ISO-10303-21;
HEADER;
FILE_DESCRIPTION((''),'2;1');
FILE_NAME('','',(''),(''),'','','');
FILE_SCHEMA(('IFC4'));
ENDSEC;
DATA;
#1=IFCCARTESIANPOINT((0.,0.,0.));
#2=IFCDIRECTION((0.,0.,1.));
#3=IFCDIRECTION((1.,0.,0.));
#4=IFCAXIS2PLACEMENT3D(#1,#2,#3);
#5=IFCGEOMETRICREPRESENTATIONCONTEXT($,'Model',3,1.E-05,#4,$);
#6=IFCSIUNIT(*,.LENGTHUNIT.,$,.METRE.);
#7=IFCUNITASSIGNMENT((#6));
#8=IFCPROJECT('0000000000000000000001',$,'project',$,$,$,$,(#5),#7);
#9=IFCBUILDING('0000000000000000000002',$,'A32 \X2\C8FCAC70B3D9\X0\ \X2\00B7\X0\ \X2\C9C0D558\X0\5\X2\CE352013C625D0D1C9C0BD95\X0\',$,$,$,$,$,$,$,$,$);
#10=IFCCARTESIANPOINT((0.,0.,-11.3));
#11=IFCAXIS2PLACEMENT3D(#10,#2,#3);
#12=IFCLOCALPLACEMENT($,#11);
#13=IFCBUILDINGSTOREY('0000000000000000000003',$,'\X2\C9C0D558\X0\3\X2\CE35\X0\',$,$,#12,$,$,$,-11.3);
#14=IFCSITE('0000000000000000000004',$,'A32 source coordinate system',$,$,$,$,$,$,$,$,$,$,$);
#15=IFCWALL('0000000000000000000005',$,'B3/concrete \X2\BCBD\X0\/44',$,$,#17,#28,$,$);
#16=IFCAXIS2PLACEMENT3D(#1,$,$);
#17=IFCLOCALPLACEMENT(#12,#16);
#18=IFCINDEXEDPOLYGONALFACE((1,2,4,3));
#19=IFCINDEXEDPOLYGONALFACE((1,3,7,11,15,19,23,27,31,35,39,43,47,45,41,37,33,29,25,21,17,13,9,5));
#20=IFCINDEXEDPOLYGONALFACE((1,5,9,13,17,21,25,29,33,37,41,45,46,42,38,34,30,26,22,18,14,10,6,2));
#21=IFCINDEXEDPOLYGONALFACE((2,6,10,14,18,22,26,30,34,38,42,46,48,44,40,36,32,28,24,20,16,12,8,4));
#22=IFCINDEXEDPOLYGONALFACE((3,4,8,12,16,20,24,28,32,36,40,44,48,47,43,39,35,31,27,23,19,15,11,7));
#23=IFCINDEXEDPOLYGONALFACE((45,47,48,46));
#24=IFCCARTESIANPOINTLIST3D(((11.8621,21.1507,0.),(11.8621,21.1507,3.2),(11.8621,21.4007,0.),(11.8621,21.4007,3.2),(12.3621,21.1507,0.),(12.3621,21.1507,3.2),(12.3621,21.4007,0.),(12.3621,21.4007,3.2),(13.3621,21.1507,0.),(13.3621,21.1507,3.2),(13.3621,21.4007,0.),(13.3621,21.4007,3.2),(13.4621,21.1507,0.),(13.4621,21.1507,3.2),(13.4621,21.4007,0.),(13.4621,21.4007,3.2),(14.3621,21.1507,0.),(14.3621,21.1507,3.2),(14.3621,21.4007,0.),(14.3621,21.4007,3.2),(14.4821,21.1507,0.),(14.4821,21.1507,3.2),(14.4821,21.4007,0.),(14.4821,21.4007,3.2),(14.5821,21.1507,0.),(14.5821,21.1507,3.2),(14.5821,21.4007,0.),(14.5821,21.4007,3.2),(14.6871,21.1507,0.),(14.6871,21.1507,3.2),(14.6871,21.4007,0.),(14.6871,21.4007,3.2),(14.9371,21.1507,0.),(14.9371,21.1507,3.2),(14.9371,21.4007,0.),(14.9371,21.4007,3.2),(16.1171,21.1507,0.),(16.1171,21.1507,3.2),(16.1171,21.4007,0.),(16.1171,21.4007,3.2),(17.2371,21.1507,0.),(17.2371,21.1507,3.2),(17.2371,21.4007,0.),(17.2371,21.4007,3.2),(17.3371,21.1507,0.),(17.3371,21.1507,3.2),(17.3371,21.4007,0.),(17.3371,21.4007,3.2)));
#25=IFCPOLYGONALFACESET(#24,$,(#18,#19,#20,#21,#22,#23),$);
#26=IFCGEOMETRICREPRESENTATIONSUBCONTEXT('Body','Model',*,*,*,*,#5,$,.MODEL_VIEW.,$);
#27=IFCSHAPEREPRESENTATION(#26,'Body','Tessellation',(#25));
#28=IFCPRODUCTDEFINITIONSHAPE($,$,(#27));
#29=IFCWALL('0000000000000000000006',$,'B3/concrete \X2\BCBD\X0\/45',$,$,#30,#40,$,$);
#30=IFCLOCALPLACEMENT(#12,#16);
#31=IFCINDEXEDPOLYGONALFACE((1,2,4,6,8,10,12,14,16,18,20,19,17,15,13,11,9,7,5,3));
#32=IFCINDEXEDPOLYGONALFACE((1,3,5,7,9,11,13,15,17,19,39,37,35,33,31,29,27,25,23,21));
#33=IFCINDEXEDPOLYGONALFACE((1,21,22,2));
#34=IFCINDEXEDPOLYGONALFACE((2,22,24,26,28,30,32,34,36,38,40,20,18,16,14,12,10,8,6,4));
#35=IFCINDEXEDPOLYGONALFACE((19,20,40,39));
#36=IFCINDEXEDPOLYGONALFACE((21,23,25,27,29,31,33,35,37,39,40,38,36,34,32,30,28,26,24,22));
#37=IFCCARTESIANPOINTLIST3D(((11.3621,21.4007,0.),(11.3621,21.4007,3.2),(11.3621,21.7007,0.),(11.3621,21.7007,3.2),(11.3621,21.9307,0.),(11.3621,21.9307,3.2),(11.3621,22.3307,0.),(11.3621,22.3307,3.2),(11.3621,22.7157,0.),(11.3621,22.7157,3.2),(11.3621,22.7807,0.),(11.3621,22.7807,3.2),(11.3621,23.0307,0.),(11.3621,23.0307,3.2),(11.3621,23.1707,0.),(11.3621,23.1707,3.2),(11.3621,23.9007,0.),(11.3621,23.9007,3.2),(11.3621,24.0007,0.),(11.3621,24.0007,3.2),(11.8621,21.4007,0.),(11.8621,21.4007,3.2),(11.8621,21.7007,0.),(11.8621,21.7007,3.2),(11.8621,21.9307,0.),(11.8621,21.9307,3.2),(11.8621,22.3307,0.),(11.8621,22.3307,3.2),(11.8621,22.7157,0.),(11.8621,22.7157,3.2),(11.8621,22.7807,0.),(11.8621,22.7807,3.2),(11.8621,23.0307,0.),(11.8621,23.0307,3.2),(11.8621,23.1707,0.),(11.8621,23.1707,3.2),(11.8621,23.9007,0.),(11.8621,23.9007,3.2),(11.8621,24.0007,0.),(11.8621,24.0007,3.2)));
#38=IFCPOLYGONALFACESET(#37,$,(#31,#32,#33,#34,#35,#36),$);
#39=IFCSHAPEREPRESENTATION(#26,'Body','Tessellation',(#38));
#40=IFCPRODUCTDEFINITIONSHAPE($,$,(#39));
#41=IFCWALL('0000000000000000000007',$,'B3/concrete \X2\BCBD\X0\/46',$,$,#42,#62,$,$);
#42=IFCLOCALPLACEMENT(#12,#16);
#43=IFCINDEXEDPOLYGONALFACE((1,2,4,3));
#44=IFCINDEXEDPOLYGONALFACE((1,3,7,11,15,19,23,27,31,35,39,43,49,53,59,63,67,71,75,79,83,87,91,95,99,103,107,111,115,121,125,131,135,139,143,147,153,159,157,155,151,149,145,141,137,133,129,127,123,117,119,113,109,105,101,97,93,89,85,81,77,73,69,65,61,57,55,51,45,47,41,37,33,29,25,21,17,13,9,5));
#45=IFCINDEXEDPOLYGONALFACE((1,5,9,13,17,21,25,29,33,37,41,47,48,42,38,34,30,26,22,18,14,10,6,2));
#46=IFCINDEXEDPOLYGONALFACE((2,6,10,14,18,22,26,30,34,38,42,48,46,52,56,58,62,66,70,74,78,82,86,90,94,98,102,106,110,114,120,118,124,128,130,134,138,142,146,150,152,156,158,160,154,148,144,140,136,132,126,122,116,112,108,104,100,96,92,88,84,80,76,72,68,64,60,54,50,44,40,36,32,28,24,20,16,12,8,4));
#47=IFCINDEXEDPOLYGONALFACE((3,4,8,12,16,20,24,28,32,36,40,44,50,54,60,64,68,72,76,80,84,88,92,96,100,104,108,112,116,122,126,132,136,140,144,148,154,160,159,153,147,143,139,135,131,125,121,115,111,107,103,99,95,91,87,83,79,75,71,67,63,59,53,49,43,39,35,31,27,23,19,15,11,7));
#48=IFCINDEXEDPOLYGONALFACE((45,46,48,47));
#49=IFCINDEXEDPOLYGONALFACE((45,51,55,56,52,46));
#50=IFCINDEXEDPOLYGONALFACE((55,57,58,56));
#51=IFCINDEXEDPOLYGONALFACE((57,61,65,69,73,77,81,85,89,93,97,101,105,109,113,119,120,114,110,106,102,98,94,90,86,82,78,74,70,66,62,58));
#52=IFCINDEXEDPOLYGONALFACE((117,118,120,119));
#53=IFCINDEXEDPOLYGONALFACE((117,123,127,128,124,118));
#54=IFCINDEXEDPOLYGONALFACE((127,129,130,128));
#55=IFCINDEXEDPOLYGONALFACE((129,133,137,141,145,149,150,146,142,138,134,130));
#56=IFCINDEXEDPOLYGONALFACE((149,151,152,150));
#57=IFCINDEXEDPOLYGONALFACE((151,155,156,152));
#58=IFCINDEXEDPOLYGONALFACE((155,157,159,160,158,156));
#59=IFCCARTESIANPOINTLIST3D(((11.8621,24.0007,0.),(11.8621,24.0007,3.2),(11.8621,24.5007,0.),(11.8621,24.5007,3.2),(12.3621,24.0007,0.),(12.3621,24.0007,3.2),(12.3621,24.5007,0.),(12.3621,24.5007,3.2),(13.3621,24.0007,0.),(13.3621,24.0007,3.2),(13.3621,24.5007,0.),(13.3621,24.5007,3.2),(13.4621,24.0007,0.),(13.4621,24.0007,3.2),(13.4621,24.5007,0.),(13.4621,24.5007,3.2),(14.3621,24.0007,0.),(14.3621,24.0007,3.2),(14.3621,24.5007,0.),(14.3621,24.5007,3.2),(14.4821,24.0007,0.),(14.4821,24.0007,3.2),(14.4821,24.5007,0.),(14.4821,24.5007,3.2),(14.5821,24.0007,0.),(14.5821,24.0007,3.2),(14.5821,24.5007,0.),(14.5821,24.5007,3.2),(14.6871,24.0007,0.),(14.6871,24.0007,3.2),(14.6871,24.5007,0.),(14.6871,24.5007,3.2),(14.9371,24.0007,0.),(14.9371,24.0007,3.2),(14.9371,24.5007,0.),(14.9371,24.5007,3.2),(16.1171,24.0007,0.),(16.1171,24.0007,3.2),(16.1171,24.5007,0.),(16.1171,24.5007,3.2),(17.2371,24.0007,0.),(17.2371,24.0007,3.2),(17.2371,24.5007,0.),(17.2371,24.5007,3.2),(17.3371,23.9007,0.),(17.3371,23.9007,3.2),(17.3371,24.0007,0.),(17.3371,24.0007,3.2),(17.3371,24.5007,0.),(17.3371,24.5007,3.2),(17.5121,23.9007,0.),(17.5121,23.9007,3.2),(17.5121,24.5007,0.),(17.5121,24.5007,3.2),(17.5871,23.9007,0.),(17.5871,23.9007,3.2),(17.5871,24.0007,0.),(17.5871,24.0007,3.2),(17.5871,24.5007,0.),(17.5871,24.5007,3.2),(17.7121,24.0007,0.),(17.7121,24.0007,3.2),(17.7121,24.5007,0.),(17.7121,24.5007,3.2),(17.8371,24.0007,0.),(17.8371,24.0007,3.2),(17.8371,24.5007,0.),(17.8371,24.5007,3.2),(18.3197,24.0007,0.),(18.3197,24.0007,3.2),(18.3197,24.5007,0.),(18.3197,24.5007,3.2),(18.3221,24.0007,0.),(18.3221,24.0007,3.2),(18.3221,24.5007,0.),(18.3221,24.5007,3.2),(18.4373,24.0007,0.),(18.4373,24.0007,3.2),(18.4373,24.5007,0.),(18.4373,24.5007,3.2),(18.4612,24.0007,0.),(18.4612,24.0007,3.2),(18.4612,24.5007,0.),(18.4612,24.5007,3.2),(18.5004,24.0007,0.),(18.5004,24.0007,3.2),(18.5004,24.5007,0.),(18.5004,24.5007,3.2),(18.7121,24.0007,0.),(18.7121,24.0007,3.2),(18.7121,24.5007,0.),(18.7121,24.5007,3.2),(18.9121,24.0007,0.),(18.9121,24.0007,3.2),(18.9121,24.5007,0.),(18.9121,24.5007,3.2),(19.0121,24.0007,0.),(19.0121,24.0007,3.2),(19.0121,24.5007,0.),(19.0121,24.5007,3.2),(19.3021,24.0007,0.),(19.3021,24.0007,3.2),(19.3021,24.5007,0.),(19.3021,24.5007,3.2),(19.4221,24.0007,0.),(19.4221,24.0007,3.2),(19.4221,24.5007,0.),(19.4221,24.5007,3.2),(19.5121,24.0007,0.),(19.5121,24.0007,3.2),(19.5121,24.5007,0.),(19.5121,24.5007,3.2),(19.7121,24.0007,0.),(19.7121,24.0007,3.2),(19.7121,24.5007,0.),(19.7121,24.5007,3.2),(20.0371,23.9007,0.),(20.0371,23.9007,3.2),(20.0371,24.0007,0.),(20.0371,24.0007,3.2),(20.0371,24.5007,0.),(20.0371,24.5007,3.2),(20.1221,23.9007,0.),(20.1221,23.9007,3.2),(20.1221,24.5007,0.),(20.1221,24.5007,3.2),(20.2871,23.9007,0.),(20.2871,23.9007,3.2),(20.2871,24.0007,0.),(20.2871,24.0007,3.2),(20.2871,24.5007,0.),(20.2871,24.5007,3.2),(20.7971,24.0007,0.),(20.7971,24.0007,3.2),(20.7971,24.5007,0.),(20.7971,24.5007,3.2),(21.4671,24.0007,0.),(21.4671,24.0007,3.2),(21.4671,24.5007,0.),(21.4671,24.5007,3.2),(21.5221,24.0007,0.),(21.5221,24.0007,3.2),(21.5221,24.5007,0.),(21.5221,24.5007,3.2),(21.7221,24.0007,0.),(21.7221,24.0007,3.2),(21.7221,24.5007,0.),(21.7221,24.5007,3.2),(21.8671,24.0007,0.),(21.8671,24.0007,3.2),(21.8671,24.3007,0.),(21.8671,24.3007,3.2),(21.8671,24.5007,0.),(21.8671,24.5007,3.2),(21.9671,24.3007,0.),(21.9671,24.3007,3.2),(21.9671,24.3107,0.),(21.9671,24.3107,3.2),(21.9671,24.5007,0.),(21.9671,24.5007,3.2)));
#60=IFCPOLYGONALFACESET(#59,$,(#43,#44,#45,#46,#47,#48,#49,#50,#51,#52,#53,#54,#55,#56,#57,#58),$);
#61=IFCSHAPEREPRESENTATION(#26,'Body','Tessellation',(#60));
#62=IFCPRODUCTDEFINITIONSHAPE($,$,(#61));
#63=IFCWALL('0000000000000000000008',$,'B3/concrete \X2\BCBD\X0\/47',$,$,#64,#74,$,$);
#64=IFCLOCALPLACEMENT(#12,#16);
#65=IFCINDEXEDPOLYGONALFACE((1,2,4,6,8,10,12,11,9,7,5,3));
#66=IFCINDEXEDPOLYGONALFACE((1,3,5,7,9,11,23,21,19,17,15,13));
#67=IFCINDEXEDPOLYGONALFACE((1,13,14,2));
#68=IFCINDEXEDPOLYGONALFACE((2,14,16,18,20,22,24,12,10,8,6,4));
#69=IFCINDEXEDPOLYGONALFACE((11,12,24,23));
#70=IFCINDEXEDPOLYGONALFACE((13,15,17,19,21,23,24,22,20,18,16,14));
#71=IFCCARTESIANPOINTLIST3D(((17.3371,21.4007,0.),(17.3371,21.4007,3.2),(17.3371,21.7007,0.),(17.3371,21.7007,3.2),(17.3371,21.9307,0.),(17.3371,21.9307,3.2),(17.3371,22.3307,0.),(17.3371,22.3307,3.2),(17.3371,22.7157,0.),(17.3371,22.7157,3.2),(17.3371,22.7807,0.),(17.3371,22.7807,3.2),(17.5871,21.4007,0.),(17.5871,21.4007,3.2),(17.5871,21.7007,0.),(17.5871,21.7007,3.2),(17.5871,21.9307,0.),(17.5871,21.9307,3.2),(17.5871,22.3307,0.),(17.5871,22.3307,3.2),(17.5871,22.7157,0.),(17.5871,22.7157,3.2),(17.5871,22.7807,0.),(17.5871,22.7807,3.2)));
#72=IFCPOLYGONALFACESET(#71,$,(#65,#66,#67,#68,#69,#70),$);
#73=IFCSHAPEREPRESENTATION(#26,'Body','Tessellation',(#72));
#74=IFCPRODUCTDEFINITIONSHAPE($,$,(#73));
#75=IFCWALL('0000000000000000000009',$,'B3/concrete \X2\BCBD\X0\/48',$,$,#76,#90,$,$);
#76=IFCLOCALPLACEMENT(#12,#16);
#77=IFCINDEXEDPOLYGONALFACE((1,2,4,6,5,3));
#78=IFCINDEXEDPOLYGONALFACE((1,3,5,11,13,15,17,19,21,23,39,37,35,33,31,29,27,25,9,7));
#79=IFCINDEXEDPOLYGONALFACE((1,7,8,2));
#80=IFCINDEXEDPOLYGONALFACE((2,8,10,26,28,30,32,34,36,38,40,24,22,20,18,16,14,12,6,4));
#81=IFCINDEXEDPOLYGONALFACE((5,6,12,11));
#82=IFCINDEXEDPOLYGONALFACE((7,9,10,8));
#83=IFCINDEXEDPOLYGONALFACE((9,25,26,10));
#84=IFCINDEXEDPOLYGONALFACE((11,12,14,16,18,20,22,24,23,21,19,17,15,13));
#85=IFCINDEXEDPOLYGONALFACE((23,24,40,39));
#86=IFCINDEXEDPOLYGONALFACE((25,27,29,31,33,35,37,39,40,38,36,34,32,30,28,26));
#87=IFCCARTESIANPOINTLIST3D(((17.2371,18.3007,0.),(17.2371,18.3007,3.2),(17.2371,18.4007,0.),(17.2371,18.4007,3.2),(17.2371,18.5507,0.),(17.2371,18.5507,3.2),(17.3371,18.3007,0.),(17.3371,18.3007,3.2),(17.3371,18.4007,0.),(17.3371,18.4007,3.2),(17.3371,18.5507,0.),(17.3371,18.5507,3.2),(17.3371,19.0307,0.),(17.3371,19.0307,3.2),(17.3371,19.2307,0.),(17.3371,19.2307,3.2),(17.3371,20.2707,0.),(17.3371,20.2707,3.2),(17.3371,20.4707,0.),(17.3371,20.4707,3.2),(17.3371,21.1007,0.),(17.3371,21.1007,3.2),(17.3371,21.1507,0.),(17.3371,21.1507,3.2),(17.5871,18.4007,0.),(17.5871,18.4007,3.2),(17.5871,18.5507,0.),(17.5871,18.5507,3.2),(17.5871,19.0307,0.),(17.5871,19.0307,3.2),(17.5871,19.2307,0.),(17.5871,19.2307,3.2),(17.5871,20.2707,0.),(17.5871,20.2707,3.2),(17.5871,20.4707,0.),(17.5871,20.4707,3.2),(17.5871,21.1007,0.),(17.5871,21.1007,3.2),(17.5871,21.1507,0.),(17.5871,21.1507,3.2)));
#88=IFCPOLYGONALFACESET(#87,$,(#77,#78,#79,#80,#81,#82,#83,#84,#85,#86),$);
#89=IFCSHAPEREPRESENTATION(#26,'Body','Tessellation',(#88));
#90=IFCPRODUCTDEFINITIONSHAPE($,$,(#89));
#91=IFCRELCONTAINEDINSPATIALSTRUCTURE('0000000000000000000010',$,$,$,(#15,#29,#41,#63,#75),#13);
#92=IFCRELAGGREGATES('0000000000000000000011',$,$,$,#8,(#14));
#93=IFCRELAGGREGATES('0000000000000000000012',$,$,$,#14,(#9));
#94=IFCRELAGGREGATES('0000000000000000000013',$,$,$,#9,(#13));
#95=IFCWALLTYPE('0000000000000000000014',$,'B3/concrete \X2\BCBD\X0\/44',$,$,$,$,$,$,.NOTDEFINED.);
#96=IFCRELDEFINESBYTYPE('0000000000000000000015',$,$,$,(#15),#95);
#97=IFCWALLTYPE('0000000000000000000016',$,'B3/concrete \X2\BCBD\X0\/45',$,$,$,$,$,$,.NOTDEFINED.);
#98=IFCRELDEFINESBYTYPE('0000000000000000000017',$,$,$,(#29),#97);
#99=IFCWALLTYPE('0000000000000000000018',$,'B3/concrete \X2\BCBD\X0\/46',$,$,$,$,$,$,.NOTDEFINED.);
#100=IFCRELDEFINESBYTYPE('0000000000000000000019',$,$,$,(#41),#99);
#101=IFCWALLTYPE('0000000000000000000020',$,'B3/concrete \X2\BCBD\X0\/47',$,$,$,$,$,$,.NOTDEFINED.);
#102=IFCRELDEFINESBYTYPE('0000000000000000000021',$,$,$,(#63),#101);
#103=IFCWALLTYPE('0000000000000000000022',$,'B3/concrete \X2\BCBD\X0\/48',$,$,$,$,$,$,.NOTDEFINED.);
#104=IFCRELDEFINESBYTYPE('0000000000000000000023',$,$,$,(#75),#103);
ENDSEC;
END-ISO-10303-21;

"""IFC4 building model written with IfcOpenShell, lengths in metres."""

from ifc_helpers import new_model, si_unit, frame, origin, origin_with_axes, place, context, subcontext, project, spatial, polyline, outline, extrude, source, transform, mapped, type_object, type_shapes, element, save


model = new_model("IFC4")

# Units and contexts
model_context = context("Model", 3, precision=1e-05, world=origin_with_axes())
body_context = subcontext(model_context, "Body", "Model", "MODEL_VIEW")
ifc_project = project(units=[si_unit("LENGTHUNIT", "METRE")], contexts=[model_context])

# Site, building, storey
site = spatial("IfcSite", under=ifc_project, Name="A32 source coordinate system")
building = spatial("IfcBuilding", under=site, Name="A32 주거동 · 지하5층–옥탑지붕")
storey_placement = place(None, frame((0.0, 0.0, -11.3), z_axis=(0.0, 0.0, 1.0), x_axis=(1.0, 0.0, 0.0)))
storey = spatial("IfcBuildingStorey", under=building, at=storey_placement, Name="지하3층", Elevation=-11.3)

# Walls
wall_type_1 = type_object("IfcWallType", Name="B3/concrete 벽/44", PredefinedType="NOTDEFINED")
shared_shape_1 = source(origin(), body_context, "Body", "SweptSolid", [
    extrude(outline(polyline([(13.3621, 21.4007), (13.4621, 21.4007), (14.3621, 21.4007), (14.4821, 21.4007), (14.5821, 21.4007), (14.6871, 21.4007), (14.9371, 21.4007), (16.1171, 21.4007), (17.2371, 21.4007), (17.3371, 21.4007), (17.3371, 21.1507), (17.2371, 21.1507), (16.1171, 21.1507), (14.9371, 21.1507), (14.6871, 21.1507), (14.5821, 21.1507), (14.4821, 21.1507), (14.3621, 21.1507), (13.4621, 21.1507), (13.3621, 21.1507), (12.3621, 21.1507), (11.8621, 21.1507), (11.8621, 21.4007), (12.3621, 21.4007), (13.3621, 21.4007)])), origin(), (0.0, 0.0, 1.0), 3.2),
])
type_shapes(wall_type_1, [shared_shape_1])
wall_1_placement = place(storey_placement, origin_with_axes())
element("IfcWall", 1, at=wall_1_placement, inside=storey, type_object=wall_type_1, Name="B3/concrete 벽/44", context=body_context, shape_type="MappedRepresentation", body=[
    mapped(shared_shape_1, transform((0.0, 0.0, 0.0), scale=1.0)),
])
wall_type_2 = type_object("IfcWallType", Name="B3/concrete 벽/45", PredefinedType="NOTDEFINED")
shared_shape_2 = source(origin(), body_context, "Body", "SweptSolid", [
    extrude(outline(polyline([(11.3621, 21.9307), (11.3621, 22.3307), (11.3621, 22.7157), (11.3621, 22.7807), (11.3621, 23.0307), (11.3621, 23.1707), (11.3621, 23.9007), (11.3621, 24.0007), (11.8621, 24.0007), (11.8621, 23.9007), (11.8621, 23.1707), (11.8621, 23.0307), (11.8621, 22.7807), (11.8621, 22.7157), (11.8621, 22.3307), (11.8621, 21.9307), (11.8621, 21.7007), (11.8621, 21.4007), (11.3621, 21.4007), (11.3621, 21.7007), (11.3621, 21.9307)])), origin(), (0.0, 0.0, 1.0), 3.2),
])
type_shapes(wall_type_2, [shared_shape_2])
wall_2_placement = place(storey_placement, origin_with_axes())
element("IfcWall", 2, at=wall_2_placement, inside=storey, type_object=wall_type_2, Name="B3/concrete 벽/45", context=body_context, shape_type="MappedRepresentation", body=[
    mapped(shared_shape_2, transform((0.0, 0.0, 0.0), scale=1.0)),
])
wall_type_3 = type_object("IfcWallType", Name="B3/concrete 벽/46", PredefinedType="NOTDEFINED")
shared_shape_3 = source(origin(), body_context, "Body", "SweptSolid", [
    extrude(outline(polyline([(13.3621, 24.5007), (13.4621, 24.5007), (14.3621, 24.5007), (14.4821, 24.5007), (14.5821, 24.5007), (14.6871, 24.5007), (14.9371, 24.5007), (16.1171, 24.5007), (17.2371, 24.5007), (17.3371, 24.5007), (17.5121, 24.5007), (17.5871, 24.5007), (17.7121, 24.5007), (17.8371, 24.5007), (18.3197, 24.5007), (18.3221, 24.5007), (18.4373, 24.5007), (18.4612, 24.5007), (18.5004, 24.5007), (18.7121, 24.5007), (18.9121, 24.5007), (19.0121, 24.5007), (19.3021, 24.5007), (19.4221, 24.5007), (19.5121, 24.5007), (19.7121, 24.5007), (20.0371, 24.5007), (20.1221, 24.5007), (20.2871, 24.5007), (20.7971, 24.5007), (21.4671, 24.5007), (21.5221, 24.5007), (21.7221, 24.5007), (21.8671, 24.5007), (21.9671, 24.5007), (21.9671, 24.3107), (21.9671, 24.3007), (21.8671, 24.3007), (21.8671, 24.0007), (21.7221, 24.0007), (21.5221, 24.0007), (21.4671, 24.0007), (20.7971, 24.0007), (20.2871, 24.0007), (20.2871, 23.9007), (20.1221, 23.9007), (20.0371, 23.9007), (20.0371, 24.0007), (19.7121, 24.0007), (19.5121, 24.0007), (19.4221, 24.0007), (19.3021, 24.0007), (19.0121, 24.0007), (18.9121, 24.0007), (18.7121, 24.0007), (18.5004, 24.0007), (18.4612, 24.0007), (18.4373, 24.0007), (18.3221, 24.0007), (18.3197, 24.0007), (17.8371, 24.0007), (17.7121, 24.0007), (17.5871, 24.0007), (17.5871, 23.9007), (17.5121, 23.9007), (17.3371, 23.9007), (17.3371, 24.0007), (17.2371, 24.0007), (16.1171, 24.0007), (14.9371, 24.0007), (14.6871, 24.0007), (14.5821, 24.0007), (14.4821, 24.0007), (14.3621, 24.0007), (13.4621, 24.0007), (13.3621, 24.0007), (12.3621, 24.0007), (11.8621, 24.0007), (11.8621, 24.5007), (12.3621, 24.5007), (13.3621, 24.5007)])), origin(), (0.0, 0.0, 1.0), 3.2),
])
type_shapes(wall_type_3, [shared_shape_3])
wall_3_placement = place(storey_placement, origin_with_axes())
element("IfcWall", 3, at=wall_3_placement, inside=storey, type_object=wall_type_3, Name="B3/concrete 벽/46", context=body_context, shape_type="MappedRepresentation", body=[
    mapped(shared_shape_3, transform((0.0, 0.0, 0.0), scale=1.0)),
])
wall_type_4 = type_object("IfcWallType", Name="B3/concrete 벽/47", PredefinedType="NOTDEFINED")
shared_shape_4 = source(origin(), body_context, "Body", "SweptSolid", [
    extrude(outline(polyline([(17.3371, 22.3307), (17.3371, 22.7157), (17.3371, 22.7807), (17.5871, 22.7807), (17.5871, 22.7157), (17.5871, 22.3307), (17.5871, 21.9307), (17.5871, 21.7007), (17.5871, 21.4007), (17.3371, 21.4007), (17.3371, 21.7007), (17.3371, 21.9307), (17.3371, 22.3307)])), origin(), (0.0, 0.0, 1.0), 3.2),
])
type_shapes(wall_type_4, [shared_shape_4])
wall_4_placement = place(storey_placement, origin_with_axes())
element("IfcWall", 4, at=wall_4_placement, inside=storey, type_object=wall_type_4, Name="B3/concrete 벽/47", context=body_context, shape_type="MappedRepresentation", body=[
    mapped(shared_shape_4, transform((0.0, 0.0, 0.0), scale=1.0)),
])
wall_type_5 = type_object("IfcWallType", Name="B3/concrete 벽/48", PredefinedType="NOTDEFINED")
shared_shape_5 = source(origin(), body_context, "Body", "SweptSolid", [
    extrude(outline(polyline([(17.5871, 20.4707), (17.5871, 20.2707), (17.5871, 19.2307), (17.5871, 19.0307), (17.5871, 18.5507), (17.5871, 18.4007), (17.3371, 18.4007), (17.3371, 18.3007), (17.2371, 18.3007), (17.2371, 18.4007), (17.2371, 18.5507), (17.3371, 18.5507), (17.3371, 19.0307), (17.3371, 19.2307), (17.3371, 20.2707), (17.3371, 20.4707), (17.3371, 21.1007), (17.3371, 21.1507), (17.5871, 21.1507), (17.5871, 21.1007), (17.5871, 20.4707)])), origin(), (0.0, 0.0, 1.0), 3.2),
])
type_shapes(wall_type_5, [shared_shape_5])
wall_5_placement = place(storey_placement, origin_with_axes())
element("IfcWall", 5, at=wall_5_placement, inside=storey, type_object=wall_type_5, Name="B3/concrete 벽/48", context=body_context, shape_type="MappedRepresentation", body=[
    mapped(shared_shape_5, transform((0.0, 0.0, 0.0), scale=1.0)),
])

save(model, "model.ifc")
